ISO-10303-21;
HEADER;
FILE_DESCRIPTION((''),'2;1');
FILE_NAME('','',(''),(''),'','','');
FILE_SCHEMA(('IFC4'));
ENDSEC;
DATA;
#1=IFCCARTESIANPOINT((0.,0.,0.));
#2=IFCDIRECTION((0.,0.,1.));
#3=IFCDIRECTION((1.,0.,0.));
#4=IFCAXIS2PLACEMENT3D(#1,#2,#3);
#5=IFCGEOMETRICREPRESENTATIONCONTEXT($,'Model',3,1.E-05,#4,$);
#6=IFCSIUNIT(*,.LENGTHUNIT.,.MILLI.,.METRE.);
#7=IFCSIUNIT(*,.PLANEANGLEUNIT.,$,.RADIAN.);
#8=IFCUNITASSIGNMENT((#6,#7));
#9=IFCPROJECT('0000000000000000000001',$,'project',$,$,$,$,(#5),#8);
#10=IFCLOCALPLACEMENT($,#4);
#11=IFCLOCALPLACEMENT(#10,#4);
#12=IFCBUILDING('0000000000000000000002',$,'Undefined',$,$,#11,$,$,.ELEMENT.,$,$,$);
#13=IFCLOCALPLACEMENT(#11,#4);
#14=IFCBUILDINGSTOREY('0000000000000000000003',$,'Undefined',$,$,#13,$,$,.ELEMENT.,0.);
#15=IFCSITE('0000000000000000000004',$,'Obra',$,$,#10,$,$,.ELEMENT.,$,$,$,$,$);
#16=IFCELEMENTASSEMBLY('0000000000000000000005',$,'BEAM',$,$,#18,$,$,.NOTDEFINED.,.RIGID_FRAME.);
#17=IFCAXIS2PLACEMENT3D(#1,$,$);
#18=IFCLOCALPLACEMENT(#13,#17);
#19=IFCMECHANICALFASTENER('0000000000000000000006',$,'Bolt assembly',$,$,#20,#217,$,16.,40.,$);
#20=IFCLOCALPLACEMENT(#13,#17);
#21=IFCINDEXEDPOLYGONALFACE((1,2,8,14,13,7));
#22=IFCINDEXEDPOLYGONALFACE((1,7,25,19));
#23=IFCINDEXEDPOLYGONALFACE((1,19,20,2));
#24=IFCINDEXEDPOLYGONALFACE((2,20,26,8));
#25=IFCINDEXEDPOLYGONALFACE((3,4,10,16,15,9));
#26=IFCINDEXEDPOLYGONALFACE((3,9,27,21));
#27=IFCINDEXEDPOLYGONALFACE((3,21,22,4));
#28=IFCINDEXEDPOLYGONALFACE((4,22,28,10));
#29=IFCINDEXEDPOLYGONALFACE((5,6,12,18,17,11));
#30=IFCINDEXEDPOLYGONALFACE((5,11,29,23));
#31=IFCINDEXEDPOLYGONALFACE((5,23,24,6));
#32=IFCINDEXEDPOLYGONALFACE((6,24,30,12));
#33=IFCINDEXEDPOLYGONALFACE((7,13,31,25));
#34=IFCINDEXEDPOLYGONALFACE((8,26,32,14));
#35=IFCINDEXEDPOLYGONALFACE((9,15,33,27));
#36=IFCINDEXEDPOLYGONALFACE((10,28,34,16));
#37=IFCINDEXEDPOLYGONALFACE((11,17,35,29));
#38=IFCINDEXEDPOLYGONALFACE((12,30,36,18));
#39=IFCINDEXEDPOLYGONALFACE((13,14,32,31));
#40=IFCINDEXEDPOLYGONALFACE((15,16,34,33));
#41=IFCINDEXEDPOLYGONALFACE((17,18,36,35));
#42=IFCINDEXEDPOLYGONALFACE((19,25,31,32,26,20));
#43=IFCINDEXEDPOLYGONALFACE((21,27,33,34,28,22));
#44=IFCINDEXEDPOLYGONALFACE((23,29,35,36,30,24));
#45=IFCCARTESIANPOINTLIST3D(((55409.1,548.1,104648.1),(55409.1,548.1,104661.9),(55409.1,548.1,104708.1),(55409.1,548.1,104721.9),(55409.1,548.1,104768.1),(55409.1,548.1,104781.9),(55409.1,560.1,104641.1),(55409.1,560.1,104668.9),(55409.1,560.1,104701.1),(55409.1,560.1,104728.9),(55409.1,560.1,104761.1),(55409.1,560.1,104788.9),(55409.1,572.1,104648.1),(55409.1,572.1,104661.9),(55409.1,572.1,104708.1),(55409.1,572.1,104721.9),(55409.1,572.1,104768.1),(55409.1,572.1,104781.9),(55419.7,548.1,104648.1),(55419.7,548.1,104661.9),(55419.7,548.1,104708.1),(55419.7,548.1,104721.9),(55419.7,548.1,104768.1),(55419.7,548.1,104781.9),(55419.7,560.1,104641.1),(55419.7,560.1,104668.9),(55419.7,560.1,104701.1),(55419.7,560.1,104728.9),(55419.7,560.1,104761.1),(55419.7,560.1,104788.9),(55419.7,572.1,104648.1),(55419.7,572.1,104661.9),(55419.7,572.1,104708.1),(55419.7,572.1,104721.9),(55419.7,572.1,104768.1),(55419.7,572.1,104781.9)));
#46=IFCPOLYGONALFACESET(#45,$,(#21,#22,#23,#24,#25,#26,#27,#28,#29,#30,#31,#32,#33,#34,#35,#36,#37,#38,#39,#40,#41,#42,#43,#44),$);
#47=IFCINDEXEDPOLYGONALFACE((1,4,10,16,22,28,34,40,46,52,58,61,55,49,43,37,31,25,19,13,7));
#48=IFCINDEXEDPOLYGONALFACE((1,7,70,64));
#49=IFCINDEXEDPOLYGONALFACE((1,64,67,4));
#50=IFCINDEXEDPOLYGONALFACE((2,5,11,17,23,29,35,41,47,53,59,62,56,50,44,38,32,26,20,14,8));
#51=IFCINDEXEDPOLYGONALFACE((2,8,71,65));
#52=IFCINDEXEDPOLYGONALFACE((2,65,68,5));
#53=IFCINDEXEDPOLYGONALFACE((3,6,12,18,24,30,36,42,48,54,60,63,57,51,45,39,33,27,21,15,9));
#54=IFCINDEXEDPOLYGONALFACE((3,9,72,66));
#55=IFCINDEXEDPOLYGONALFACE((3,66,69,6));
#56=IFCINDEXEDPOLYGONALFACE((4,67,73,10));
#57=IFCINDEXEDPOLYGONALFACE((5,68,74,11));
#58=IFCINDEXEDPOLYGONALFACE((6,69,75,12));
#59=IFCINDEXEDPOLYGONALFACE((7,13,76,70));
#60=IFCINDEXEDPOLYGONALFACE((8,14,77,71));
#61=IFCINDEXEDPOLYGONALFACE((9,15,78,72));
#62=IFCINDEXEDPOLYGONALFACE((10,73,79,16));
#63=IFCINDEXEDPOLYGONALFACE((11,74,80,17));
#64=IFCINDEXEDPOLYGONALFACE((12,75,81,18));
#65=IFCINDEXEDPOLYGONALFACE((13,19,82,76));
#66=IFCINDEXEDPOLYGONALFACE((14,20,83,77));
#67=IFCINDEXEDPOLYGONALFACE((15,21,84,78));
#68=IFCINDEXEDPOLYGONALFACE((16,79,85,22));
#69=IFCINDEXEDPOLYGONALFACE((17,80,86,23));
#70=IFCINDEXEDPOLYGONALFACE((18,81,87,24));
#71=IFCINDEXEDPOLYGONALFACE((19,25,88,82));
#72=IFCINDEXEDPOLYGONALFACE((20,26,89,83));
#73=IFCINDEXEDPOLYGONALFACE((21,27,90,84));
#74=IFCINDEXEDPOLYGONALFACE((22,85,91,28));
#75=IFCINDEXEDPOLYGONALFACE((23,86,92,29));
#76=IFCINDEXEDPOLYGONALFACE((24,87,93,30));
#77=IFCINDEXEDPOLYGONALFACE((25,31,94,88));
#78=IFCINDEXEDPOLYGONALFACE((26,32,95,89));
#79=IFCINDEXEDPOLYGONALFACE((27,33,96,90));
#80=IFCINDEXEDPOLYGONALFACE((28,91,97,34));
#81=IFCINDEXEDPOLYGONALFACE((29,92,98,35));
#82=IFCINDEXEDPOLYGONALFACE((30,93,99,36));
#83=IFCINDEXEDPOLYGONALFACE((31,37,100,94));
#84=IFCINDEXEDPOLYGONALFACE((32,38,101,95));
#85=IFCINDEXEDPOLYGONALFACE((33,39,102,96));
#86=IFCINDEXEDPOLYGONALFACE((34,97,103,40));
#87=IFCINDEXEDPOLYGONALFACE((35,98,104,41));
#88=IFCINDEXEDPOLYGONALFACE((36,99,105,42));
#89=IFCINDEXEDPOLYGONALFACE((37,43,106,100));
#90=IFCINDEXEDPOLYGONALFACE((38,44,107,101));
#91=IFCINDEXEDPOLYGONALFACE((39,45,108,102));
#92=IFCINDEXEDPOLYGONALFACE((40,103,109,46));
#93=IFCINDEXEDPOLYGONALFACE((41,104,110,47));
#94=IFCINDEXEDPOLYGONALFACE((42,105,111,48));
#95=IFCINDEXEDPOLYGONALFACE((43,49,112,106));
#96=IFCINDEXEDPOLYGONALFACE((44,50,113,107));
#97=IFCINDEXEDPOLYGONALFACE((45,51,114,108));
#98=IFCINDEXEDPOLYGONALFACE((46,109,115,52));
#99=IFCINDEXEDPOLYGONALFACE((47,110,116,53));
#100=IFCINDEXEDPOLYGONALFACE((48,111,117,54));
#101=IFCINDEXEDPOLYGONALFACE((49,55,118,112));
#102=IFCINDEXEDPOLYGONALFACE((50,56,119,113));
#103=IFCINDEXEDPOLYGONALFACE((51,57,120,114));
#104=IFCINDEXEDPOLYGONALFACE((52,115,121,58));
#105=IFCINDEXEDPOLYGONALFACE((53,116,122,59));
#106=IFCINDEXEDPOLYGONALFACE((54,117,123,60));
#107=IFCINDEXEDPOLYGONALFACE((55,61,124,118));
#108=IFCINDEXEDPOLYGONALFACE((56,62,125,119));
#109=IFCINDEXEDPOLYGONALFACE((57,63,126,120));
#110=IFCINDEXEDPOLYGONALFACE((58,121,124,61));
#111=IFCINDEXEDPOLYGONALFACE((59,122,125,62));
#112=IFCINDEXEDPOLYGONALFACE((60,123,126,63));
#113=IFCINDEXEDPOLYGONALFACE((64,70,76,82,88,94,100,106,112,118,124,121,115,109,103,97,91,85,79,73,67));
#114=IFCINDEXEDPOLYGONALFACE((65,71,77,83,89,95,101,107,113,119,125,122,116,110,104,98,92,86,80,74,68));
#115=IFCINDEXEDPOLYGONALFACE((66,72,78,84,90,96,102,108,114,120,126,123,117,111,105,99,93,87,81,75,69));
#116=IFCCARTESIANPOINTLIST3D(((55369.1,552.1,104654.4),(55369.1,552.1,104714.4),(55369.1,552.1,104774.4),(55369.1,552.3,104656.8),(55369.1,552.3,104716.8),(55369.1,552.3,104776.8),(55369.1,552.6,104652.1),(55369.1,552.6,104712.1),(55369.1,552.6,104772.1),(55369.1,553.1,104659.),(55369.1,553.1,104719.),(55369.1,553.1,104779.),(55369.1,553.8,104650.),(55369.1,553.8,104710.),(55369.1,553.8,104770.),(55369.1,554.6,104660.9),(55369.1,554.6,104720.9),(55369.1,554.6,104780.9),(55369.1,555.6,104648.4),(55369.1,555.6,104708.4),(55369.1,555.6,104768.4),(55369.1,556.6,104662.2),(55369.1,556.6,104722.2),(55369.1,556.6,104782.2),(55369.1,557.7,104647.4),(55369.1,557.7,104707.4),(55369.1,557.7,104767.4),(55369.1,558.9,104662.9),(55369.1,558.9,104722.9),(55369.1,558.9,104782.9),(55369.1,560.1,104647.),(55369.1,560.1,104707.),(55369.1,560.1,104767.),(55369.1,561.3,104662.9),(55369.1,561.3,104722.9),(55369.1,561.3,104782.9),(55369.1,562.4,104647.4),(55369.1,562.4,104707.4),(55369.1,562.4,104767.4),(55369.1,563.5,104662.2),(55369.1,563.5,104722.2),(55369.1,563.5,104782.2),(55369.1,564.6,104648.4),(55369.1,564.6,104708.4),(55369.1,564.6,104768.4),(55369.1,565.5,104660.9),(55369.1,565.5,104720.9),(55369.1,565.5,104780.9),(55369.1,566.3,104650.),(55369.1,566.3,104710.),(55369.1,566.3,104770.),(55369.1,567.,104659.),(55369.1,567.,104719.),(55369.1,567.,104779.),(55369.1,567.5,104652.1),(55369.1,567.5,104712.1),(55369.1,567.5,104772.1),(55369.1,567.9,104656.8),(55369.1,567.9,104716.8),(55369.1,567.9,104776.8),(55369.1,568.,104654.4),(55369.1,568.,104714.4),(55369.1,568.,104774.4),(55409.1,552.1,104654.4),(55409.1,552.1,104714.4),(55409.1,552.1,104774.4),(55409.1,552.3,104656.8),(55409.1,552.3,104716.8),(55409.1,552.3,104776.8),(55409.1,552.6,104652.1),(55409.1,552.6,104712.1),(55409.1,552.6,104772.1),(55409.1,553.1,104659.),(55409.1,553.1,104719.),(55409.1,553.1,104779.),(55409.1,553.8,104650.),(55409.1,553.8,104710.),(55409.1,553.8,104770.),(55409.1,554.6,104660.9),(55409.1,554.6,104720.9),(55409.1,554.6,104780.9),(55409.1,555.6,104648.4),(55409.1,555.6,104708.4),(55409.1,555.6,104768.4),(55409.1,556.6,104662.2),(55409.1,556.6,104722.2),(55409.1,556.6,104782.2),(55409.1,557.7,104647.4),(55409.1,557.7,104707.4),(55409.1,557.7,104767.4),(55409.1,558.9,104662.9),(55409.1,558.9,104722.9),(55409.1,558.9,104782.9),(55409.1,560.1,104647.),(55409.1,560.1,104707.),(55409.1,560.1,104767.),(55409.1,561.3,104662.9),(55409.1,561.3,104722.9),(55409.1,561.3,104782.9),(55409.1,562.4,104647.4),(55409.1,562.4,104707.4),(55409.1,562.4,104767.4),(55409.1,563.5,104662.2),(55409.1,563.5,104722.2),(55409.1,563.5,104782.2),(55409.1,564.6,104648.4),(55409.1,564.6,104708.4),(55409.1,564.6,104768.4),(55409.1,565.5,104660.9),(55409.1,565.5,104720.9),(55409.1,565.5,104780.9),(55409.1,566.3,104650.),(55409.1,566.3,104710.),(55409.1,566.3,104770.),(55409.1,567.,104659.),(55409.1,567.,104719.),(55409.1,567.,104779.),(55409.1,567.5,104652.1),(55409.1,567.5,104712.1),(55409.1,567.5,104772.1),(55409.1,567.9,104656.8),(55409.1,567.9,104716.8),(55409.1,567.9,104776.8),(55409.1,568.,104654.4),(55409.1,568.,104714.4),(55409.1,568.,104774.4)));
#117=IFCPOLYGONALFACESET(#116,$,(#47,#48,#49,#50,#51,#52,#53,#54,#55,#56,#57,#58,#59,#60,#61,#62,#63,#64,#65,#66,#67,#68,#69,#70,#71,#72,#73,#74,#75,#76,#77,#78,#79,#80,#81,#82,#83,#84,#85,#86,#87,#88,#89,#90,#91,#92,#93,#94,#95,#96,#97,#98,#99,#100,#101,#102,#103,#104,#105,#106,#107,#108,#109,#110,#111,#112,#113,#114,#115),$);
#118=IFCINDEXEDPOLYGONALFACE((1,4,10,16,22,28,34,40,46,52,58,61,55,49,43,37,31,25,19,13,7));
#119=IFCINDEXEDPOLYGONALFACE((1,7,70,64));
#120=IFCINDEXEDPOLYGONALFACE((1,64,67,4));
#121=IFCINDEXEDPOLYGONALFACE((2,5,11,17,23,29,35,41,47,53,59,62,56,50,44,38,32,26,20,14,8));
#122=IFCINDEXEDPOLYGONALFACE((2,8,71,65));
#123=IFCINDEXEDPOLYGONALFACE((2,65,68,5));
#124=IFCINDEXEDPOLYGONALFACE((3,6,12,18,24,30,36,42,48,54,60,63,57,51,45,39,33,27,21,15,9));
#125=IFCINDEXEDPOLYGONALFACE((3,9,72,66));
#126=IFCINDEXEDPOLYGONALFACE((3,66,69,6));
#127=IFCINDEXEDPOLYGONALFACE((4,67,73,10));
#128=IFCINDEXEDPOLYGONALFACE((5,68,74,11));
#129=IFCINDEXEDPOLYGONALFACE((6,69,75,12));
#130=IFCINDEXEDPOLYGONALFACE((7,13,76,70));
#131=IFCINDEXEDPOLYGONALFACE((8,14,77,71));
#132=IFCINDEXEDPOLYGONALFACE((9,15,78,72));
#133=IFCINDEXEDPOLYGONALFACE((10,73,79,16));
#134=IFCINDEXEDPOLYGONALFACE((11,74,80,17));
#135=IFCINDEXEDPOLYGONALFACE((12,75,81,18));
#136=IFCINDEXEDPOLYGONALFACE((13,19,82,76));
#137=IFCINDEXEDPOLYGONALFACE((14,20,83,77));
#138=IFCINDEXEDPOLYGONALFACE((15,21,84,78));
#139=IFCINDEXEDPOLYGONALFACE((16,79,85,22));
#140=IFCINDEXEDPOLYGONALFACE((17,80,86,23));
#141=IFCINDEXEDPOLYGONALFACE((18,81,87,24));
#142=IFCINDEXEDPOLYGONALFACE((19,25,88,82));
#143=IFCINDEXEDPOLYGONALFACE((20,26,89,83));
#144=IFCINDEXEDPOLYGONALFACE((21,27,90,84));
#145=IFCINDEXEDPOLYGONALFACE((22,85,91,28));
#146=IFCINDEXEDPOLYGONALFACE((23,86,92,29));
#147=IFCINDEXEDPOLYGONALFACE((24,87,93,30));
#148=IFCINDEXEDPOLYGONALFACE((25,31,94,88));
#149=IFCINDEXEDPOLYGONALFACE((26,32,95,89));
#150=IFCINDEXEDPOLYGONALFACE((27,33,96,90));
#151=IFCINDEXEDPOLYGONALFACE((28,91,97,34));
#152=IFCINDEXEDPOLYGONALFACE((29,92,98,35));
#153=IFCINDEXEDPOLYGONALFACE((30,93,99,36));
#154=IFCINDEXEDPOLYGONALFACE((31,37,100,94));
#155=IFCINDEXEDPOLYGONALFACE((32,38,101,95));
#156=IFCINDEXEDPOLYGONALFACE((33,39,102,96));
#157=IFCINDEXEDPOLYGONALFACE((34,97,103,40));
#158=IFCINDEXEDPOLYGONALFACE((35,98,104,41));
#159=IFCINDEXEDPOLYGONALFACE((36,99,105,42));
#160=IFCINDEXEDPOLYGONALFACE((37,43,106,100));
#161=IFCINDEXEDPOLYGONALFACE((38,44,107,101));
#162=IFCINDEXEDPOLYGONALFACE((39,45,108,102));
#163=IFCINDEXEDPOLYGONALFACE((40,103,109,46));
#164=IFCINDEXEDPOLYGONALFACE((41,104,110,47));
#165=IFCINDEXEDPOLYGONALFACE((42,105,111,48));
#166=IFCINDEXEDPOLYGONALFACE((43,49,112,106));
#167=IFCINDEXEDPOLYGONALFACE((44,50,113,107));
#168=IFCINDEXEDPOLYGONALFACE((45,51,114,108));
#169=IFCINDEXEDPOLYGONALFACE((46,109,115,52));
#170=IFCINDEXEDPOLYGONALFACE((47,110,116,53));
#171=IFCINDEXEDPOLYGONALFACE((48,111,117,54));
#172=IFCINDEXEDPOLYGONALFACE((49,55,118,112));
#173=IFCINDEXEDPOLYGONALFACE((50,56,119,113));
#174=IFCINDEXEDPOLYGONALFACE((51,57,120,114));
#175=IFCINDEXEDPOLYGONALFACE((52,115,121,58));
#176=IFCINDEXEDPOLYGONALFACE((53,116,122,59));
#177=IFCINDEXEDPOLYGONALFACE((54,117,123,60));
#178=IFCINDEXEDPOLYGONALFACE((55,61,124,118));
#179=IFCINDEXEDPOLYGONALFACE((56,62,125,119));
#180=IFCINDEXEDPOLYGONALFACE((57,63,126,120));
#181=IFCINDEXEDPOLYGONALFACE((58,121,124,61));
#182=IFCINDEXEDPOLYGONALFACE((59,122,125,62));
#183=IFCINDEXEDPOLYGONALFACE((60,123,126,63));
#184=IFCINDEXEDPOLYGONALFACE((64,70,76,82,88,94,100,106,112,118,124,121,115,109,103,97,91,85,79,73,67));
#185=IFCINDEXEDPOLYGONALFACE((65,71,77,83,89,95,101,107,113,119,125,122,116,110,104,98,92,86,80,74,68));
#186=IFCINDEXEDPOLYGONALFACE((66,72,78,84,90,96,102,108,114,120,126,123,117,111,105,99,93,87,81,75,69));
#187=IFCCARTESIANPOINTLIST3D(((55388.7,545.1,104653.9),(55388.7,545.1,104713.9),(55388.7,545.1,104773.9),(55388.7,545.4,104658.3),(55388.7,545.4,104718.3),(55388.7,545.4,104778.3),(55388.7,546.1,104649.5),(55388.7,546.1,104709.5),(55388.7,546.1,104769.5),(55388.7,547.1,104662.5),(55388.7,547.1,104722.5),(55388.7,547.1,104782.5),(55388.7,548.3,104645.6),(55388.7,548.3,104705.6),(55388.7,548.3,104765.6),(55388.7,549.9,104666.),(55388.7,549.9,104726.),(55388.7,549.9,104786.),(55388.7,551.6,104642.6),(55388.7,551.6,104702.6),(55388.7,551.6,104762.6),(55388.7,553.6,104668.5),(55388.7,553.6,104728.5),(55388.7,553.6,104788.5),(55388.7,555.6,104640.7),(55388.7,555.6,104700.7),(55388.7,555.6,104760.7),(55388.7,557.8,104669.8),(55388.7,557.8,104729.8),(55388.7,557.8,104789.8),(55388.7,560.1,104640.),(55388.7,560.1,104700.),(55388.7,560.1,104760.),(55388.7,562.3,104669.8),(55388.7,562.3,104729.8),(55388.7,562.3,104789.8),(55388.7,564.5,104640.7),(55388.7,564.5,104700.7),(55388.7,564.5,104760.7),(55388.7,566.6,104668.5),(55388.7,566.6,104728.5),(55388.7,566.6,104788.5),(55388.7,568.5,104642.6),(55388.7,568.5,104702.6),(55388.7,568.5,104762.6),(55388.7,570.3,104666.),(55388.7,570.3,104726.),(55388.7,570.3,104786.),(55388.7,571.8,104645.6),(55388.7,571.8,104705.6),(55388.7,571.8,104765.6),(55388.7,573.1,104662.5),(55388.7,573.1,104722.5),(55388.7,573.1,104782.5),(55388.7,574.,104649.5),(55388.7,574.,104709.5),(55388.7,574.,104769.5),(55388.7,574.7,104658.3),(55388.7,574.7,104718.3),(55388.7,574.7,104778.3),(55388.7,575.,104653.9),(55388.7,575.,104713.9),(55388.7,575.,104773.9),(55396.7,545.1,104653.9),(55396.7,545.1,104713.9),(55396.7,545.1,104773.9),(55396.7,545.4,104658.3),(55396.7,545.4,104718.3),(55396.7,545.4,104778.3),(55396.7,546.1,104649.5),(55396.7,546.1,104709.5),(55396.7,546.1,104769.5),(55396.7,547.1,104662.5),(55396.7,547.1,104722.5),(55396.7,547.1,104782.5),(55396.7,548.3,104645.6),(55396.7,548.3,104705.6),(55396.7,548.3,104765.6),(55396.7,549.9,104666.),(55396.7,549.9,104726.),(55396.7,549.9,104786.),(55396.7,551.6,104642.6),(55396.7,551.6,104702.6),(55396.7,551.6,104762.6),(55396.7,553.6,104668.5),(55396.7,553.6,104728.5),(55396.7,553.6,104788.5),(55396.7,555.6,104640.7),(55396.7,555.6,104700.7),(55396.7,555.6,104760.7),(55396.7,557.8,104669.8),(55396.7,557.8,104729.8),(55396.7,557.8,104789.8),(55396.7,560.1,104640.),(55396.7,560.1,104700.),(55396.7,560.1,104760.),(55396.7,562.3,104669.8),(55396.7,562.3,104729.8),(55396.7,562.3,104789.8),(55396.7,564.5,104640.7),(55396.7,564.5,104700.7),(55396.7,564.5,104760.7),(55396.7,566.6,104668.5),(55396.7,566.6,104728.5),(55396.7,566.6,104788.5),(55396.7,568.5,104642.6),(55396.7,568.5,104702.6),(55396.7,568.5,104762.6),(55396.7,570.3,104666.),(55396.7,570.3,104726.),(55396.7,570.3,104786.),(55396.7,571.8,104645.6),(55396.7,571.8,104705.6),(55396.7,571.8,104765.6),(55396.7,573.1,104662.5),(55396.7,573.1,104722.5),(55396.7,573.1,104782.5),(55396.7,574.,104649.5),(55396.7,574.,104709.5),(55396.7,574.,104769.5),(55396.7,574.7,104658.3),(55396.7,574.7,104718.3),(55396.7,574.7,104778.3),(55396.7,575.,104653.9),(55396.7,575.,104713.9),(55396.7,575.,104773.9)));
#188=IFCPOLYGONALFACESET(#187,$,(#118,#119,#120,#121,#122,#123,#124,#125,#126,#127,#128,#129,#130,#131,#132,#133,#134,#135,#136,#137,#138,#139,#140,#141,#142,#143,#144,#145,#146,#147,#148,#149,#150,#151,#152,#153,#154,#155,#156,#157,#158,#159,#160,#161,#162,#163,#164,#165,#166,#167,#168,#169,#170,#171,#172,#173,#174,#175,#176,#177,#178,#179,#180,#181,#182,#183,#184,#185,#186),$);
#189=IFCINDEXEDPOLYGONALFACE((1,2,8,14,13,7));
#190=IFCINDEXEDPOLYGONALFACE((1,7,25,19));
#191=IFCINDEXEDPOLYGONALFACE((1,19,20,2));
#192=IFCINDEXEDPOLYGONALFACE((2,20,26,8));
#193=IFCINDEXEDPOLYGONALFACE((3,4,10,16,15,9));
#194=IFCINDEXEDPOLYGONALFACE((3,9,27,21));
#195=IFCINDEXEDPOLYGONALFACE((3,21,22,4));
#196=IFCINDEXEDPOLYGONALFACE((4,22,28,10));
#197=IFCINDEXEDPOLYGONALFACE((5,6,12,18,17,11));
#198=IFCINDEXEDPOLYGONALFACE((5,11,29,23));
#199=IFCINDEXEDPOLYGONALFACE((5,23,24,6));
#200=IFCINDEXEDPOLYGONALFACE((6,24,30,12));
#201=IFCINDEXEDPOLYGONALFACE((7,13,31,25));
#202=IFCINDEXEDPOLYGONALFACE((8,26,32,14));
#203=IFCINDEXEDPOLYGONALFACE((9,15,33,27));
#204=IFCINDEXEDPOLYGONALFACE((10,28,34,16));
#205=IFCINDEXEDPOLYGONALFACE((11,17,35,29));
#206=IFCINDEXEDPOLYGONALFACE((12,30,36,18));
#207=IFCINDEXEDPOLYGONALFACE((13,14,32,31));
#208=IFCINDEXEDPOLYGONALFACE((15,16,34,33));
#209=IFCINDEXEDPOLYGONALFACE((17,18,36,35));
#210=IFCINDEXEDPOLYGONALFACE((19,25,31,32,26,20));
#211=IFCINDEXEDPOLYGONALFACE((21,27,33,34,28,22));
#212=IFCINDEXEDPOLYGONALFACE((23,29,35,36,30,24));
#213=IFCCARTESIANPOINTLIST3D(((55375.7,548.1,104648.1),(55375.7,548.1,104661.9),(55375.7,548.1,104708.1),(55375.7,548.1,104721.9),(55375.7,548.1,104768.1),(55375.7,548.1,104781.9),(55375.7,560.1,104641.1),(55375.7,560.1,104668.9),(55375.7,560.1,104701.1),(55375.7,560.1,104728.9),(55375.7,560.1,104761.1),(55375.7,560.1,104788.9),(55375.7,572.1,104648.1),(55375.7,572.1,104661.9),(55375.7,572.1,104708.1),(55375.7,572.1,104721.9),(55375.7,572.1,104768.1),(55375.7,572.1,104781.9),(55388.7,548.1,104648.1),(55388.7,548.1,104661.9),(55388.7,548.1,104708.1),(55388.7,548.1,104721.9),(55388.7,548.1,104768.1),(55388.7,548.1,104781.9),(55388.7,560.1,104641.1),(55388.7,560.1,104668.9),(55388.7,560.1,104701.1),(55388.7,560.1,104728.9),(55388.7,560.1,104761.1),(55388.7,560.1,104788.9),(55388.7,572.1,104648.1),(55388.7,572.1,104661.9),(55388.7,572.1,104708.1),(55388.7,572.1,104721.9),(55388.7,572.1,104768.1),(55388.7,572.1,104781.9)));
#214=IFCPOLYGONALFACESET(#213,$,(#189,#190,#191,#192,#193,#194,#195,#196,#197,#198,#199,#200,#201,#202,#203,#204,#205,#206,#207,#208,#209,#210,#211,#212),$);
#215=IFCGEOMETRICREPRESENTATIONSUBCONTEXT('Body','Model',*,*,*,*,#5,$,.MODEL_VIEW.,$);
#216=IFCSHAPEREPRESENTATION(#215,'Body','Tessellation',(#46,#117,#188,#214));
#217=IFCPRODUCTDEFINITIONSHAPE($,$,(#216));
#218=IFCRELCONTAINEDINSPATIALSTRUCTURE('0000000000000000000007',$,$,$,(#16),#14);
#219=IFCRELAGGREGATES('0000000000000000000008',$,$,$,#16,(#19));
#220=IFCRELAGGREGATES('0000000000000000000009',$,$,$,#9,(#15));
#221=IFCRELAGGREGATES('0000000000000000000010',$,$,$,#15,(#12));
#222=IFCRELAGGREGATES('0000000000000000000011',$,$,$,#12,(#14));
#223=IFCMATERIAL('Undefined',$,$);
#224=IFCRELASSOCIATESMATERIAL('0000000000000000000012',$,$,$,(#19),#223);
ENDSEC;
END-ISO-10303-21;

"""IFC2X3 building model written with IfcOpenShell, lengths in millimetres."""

from ifc_helpers import new_model, si_unit, frame, origin_with_axes, origin_2d_with_axis, place, context, subcontext, project, spatial, polyline, circle, outline, extrude, source, transform, mapped, material, element, aggregate, save


model = new_model("IFC2X3")

# Units and contexts
model_context = context("Model", 3, precision=1e-05, world=origin_with_axes())
body_context = subcontext(model_context, "Body", "Model", "MODEL_VIEW")
ifc_project = project(units=[si_unit("LENGTHUNIT", "METRE", prefix="MILLI"), si_unit("PLANEANGLEUNIT", "RADIAN")], contexts=[model_context])

# Site, building, storey
site_placement = place(None, origin_with_axes())
site = spatial("IfcSite", under=ifc_project, at=site_placement, Name="Obra", CompositionType="ELEMENT")
building_placement = place(site_placement, origin_with_axes())
building = spatial("IfcBuilding", under=site, at=building_placement, Name="Undefined", CompositionType="ELEMENT")
storey_placement = place(building_placement, origin_with_axes())
storey = spatial("IfcBuildingStorey", under=building, at=storey_placement, Name="Undefined", CompositionType="ELEMENT", Elevation=0.0)

# Element assembly, mechanical fastener
ifc_material_1 = material(Name="Undefined")
shared_shape_1 = source(origin_with_axes(), body_context, "Body", "SweptSolid", [
    extrude(outline(polyline([(13.9, 0.0), (6.9, 12.0), (-6.9, 12.0), (-13.9, 0.0), (-6.9, -12.0), (6.9, -12.0), (13.9, 0.0)])), frame((0.0, -19.7, 0.0), z_axis=(0.0, 1.0, 0.0), x_axis=(1.0, 0.0, 0.0)), (0.0, 0.0, 1.0), 10.6),
    extrude(circle(Radius=8.0, at=origin_2d_with_axis()), frame((0.0, -9.1, 0.0), z_axis=(0.0, 1.0, 0.0), x_axis=(1.0, 0.0, 0.0)), (0.0, 0.0, 1.0), 40.0),
    extrude(circle(Radius=15.0, at=origin_2d_with_axis()), frame((0.0, 3.3, 0.0), z_axis=(0.0, 1.0, 0.0), x_axis=(1.0, 0.0, 0.0)), (0.0, 0.0, 1.0), 8.0),
    extrude(outline(polyline([(13.9, 0.0), (6.9, 12.0), (-6.9, 12.0), (-13.9, 0.0), (-6.9, -12.0), (6.9, -12.0), (13.9, 0.0)])), frame((0.0, 11.3, 0.0), z_axis=(0.0, 1.0, 0.0), x_axis=(1.0, 0.0, 0.0)), (0.0, 0.0, 1.0), 13.0),
])
assembly_1_placement = place(storey_placement, origin_with_axes())
assembly_1 = element("IfcElementAssembly", 1, at=assembly_1_placement, inside=storey, Name="BEAM", AssemblyPlace="NOTDEFINED", PredefinedType="RIGID_FRAME")
mechanical_fastener_1_placement = place(assembly_1_placement, frame((55400.0, 510.1, 104835.0), z_axis=(-0.000002, 1.0, 0.0), x_axis=(0.0, 0.0, -1.0)))
mechanical_fastener_1 = element("IfcMechanicalFastener", 2, at=mechanical_fastener_1_placement, material=ifc_material_1, Name="Bolt assembly", NominalDiameter=16.0, NominalLength=40.0, context=body_context, shape_type="MappedRepresentation", body=[
    mapped(shared_shape_1, transform((60.0, 0.0, 50.0))),
    mapped(shared_shape_1, transform((120.0, 0.0, 50.0))),
    mapped(shared_shape_1, transform((180.0, 0.0, 50.0))),
])

aggregate(assembly_1, [mechanical_fastener_1])

save(model, "model.ifc")
